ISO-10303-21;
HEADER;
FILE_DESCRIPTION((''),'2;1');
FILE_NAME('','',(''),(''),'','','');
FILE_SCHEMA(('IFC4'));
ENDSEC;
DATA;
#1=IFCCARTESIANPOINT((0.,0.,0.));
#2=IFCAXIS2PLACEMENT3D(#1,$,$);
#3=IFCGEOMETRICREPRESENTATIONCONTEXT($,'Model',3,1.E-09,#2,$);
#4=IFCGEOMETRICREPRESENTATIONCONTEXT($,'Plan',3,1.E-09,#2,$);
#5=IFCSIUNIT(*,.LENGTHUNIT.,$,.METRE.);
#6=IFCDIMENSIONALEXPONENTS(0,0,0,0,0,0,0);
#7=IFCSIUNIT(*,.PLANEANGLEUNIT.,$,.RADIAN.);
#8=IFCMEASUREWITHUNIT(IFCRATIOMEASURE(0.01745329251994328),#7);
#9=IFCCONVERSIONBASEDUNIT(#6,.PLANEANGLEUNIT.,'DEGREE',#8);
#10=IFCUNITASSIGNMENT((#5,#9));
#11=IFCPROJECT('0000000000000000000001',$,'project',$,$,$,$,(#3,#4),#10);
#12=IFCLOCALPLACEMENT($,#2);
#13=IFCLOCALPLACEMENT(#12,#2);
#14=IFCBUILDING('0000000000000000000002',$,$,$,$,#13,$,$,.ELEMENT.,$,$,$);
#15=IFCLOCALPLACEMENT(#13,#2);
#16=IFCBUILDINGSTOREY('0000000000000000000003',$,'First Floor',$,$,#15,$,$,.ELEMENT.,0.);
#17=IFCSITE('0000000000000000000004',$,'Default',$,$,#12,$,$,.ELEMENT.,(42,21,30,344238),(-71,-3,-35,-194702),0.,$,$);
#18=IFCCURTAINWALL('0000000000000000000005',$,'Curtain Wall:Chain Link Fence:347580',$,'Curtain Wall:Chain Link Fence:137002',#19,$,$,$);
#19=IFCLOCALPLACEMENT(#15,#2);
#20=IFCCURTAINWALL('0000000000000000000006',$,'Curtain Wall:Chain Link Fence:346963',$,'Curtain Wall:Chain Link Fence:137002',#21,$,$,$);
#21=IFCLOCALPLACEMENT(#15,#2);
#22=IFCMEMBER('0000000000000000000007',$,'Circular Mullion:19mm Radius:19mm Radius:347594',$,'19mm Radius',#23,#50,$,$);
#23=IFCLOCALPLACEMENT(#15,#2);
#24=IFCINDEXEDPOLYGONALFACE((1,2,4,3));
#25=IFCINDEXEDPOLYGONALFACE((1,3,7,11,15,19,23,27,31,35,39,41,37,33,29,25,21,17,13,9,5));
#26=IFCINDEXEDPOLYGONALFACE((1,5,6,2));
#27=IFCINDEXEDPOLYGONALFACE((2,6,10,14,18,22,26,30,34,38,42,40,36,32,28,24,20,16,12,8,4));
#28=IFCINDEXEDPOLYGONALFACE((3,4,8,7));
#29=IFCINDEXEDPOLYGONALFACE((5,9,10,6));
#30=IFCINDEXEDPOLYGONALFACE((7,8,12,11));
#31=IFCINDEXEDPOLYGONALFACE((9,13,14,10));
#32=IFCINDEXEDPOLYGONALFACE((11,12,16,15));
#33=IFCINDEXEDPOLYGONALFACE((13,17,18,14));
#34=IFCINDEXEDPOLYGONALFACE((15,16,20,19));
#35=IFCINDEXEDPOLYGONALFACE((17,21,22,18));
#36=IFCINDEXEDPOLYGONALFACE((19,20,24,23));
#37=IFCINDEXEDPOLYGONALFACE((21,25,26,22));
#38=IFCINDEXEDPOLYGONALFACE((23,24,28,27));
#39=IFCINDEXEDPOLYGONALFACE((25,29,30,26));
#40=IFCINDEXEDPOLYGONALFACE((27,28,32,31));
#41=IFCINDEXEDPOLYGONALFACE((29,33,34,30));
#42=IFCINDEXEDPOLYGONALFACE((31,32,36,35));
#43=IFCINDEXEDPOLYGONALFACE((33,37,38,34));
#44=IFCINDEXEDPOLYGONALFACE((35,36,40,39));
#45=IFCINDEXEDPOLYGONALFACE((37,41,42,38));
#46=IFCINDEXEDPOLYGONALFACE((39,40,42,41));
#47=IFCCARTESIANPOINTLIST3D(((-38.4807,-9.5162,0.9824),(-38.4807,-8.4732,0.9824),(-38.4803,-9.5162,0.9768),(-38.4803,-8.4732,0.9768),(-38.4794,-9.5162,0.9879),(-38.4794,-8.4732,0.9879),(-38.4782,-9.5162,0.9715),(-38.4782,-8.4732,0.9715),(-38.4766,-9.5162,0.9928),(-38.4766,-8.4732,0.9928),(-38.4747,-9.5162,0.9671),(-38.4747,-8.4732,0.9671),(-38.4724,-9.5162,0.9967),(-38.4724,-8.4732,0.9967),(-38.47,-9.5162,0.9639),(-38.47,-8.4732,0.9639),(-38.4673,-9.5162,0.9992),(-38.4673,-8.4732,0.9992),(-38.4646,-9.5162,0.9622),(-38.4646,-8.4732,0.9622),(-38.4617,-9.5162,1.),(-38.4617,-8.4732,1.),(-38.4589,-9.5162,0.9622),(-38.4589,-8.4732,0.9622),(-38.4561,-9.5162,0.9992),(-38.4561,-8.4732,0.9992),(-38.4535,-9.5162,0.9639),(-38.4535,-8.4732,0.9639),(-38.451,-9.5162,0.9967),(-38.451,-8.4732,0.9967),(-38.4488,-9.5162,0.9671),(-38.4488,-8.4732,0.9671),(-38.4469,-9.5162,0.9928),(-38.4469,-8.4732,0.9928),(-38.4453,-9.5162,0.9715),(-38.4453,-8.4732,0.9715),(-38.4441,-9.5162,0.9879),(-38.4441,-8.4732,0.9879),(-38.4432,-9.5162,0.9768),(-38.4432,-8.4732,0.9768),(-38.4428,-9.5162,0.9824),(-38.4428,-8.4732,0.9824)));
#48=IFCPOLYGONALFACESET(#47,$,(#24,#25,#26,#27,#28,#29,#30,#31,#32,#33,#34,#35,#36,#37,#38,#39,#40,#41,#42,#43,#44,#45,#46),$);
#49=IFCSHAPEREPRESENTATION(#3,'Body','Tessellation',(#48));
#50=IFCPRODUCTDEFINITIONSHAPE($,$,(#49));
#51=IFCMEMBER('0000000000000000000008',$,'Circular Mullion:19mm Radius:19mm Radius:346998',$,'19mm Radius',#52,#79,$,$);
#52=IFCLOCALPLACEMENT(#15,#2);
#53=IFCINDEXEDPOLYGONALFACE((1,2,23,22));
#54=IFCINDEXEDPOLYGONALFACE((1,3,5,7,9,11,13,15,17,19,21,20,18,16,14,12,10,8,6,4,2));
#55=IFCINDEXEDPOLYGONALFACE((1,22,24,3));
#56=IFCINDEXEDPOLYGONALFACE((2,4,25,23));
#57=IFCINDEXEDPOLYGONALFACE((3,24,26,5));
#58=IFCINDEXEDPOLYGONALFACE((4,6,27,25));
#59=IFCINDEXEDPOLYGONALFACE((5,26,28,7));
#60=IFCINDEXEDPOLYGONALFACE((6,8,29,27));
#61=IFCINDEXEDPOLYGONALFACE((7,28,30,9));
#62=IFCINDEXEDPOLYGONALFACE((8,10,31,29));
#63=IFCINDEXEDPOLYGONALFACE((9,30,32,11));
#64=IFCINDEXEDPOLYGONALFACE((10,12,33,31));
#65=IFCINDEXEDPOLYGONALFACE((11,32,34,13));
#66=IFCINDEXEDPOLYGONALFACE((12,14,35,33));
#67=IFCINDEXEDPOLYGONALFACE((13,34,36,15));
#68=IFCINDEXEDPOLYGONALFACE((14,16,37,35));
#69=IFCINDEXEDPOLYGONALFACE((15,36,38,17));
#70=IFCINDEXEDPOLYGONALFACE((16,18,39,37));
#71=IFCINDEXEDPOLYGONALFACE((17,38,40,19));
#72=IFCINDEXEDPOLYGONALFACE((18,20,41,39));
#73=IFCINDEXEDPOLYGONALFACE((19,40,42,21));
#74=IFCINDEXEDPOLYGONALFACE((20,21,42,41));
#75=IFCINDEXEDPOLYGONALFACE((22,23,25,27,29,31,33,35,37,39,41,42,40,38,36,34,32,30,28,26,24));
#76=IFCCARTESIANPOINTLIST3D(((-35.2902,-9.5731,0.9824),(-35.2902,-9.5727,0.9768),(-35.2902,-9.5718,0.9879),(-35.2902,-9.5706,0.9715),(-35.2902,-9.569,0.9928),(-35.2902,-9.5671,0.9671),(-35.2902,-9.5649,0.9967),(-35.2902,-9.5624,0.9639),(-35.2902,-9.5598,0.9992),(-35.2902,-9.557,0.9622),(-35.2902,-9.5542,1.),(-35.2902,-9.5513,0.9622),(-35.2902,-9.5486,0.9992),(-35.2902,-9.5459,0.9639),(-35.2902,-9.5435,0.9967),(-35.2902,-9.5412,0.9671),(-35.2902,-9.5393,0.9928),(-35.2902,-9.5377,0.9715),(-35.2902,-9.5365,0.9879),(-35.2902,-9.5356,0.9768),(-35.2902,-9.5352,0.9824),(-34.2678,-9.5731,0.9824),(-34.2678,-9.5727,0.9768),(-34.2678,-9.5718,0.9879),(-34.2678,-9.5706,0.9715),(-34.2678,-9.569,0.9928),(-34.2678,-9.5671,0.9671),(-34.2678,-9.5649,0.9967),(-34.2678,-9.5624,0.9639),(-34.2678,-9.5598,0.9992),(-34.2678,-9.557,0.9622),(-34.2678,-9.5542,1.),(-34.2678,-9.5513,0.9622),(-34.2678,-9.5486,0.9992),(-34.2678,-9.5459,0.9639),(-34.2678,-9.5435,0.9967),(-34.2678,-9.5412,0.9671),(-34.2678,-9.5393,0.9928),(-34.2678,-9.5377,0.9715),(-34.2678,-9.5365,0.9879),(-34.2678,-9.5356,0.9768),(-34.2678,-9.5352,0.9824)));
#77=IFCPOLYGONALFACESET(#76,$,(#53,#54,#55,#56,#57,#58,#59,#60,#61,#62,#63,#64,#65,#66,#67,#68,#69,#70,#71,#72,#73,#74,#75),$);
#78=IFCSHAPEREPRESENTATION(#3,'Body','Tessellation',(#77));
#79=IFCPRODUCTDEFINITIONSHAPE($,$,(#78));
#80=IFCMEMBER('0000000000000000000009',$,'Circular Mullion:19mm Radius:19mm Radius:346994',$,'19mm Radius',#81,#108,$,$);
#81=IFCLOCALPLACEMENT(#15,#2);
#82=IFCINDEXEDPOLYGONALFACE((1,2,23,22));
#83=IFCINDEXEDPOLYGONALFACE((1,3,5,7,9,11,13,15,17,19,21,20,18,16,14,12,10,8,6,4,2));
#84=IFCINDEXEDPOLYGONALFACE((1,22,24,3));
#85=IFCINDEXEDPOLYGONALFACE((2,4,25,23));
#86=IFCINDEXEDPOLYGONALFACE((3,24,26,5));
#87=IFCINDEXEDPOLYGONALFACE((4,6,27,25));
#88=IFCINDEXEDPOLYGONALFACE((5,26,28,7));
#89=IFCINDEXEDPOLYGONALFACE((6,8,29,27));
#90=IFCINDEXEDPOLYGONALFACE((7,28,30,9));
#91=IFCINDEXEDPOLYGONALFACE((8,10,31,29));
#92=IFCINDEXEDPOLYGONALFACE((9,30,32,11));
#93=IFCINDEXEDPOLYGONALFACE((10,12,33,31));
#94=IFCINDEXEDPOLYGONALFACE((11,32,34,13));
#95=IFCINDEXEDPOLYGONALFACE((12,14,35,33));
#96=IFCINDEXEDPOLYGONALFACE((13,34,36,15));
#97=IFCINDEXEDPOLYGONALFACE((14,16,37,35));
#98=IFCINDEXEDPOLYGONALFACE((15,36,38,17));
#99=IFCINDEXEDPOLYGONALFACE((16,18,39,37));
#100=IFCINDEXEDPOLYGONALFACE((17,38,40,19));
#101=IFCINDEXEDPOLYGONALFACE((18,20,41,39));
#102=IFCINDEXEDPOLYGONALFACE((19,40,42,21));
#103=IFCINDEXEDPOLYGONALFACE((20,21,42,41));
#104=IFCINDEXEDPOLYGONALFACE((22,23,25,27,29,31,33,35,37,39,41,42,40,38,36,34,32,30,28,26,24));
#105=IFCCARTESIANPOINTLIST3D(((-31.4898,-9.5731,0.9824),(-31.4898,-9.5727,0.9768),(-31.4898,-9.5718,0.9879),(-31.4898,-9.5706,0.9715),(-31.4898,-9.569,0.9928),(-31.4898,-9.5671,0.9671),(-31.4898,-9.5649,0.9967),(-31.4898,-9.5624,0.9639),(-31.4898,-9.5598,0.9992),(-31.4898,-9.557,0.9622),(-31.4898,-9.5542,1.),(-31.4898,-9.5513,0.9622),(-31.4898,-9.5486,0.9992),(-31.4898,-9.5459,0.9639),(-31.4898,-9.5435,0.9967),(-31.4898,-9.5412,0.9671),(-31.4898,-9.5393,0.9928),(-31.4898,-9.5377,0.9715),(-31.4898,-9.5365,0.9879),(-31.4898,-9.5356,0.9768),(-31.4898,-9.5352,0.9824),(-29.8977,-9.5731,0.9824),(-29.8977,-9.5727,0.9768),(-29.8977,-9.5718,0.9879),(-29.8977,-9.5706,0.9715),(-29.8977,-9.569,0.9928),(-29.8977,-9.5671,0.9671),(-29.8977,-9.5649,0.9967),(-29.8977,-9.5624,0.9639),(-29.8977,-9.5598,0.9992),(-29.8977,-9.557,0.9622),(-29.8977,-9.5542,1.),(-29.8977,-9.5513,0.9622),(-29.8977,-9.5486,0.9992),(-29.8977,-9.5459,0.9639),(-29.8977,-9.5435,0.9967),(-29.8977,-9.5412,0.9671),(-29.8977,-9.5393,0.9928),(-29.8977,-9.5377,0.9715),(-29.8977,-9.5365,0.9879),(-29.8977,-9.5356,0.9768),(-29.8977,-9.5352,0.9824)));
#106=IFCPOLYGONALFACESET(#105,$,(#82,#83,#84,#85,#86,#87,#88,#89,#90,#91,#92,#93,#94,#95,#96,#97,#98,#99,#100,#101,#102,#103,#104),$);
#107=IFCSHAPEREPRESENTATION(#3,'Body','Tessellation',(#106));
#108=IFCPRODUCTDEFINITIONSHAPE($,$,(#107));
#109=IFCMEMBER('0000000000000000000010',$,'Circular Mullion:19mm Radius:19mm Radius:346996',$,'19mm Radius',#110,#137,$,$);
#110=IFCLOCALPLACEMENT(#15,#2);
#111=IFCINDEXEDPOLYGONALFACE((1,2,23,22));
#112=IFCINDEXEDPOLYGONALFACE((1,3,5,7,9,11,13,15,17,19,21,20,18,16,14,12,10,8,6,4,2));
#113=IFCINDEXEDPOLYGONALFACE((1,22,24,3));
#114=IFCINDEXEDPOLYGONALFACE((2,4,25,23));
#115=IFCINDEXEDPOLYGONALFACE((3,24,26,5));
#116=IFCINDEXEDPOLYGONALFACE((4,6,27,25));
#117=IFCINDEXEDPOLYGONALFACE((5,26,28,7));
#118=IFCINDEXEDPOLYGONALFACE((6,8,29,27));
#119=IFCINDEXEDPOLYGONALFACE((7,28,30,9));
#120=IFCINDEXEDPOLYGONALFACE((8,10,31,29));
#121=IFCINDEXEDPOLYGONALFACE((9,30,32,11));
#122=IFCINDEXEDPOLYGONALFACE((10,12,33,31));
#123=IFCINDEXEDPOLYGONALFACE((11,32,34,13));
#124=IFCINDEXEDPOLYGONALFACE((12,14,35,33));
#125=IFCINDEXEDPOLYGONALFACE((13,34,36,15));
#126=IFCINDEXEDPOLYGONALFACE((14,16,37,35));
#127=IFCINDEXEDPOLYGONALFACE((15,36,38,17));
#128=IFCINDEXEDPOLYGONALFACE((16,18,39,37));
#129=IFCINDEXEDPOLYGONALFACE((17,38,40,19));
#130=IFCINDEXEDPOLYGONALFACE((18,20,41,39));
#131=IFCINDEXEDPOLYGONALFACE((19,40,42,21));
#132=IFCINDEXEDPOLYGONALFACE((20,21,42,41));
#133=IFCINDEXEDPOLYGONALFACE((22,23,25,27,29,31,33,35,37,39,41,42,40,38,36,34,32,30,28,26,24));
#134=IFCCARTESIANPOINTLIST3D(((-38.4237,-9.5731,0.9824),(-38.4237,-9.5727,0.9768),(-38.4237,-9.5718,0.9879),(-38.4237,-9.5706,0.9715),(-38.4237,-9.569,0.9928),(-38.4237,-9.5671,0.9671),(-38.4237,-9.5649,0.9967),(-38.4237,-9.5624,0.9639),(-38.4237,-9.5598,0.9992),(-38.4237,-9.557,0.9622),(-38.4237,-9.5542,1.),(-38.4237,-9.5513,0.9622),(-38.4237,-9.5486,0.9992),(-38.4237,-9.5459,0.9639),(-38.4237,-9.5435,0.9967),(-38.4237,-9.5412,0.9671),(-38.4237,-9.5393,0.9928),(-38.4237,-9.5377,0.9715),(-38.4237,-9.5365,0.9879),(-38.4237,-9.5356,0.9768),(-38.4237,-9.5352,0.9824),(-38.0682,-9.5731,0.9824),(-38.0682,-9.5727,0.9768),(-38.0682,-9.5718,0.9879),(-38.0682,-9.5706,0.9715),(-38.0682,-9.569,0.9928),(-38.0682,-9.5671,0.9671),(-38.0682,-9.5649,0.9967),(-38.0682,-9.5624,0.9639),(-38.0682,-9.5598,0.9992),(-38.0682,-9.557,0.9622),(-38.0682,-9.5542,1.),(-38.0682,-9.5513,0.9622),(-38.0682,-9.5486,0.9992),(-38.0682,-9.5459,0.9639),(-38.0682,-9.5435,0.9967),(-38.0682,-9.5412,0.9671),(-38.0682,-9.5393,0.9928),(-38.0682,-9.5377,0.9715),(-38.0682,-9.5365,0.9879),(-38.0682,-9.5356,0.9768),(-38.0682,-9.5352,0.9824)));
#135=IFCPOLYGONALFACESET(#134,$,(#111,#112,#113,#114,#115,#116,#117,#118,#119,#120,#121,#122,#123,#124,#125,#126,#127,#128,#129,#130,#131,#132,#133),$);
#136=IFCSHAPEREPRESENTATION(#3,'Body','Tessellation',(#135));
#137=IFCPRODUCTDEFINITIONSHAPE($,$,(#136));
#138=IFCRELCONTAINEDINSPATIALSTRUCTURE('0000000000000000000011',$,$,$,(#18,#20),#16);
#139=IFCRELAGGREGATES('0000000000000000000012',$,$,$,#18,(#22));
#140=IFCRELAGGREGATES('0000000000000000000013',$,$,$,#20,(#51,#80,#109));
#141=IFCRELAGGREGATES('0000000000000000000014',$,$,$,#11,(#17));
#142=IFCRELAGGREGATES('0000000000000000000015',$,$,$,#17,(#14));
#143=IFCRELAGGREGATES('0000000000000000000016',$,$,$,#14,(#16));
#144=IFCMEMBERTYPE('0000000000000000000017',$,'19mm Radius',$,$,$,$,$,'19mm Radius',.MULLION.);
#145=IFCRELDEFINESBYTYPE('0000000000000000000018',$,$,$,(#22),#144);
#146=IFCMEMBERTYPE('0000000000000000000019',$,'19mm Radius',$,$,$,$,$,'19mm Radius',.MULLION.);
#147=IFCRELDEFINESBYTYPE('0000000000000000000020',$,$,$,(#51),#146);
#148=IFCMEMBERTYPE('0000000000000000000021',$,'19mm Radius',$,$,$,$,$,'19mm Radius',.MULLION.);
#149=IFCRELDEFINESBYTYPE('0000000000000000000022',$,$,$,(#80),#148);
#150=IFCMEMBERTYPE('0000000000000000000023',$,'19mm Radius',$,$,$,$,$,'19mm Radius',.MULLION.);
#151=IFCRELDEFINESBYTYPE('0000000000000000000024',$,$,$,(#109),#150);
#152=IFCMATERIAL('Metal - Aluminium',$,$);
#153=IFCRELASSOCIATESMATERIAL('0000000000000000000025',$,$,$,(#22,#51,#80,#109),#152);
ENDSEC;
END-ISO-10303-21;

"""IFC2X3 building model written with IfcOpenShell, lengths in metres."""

from ifc_helpers import new_model, entity, si_unit, converted_unit, frame, origin, origin_2d_with_axis, place, context, project, spatial, circle, extrude, source, transform, mapped, material, type_object, type_shapes, element, aggregate, save


model = new_model("IFC2X3")

# Units and contexts
model_context = context("Model", 3, precision=1e-09, world=origin())
plan_context = context("Plan", 3, precision=1e-09, world=origin())
ifc_project = project(units=[si_unit("LENGTHUNIT", "METRE"), converted_unit("PLANEANGLEUNIT", "DEGREE", entity("IfcRatioMeasure", 0.01745329251994328), si_unit("PLANEANGLEUNIT", "RADIAN"), dimensions=[0, 0, 0, 0, 0, 0, 0])], contexts=[model_context, plan_context])

# Site, building, storey
site_placement = place(None, origin())
site = spatial("IfcSite", under=ifc_project, at=site_placement, Name="Default", CompositionType="ELEMENT", RefLatitude=(42, 21, 30, 344238), RefLongitude=(-71, -3, -35, -194702), RefElevation=0.0)
building_placement = place(site_placement, origin())
building = spatial("IfcBuilding", under=site, at=building_placement, CompositionType="ELEMENT")
storey_placement = place(building_placement, origin())
storey = spatial("IfcBuildingStorey", under=building, at=storey_placement, Name="First Floor", CompositionType="ELEMENT", Elevation=0.0)

# Curtain walls
curtain_wall_1_placement = place(storey_placement, origin())
curtain_wall_1 = element("IfcCurtainWall", 1, at=curtain_wall_1_placement, inside=storey, Name="Curtain Wall:Chain Link Fence:347580", ObjectType="Curtain Wall:Chain Link Fence:137002")
ifc_material_1 = material(Name="Metal - Aluminium")
curtain_wall_2_placement = place(storey_placement, origin())
curtain_wall_2 = element("IfcCurtainWall", 2, at=curtain_wall_2_placement, inside=storey, Name="Curtain Wall:Chain Link Fence:346963", ObjectType="Curtain Wall:Chain Link Fence:137002")

# Members
member_type_1 = type_object("IfcMemberType", Name="19mm Radius", ElementType="19mm Radius", PredefinedType="MULLION")
shared_shape_1 = source(origin(), model_context, "Body", "SweptSolid", [
    extrude(circle(Radius=0.019, at=origin_2d_with_axis()), frame((-0.019, 0.0, -1.043)), (0.0, 0.0, 1.0), 1.043),
])
type_shapes(member_type_1, [shared_shape_1])
member_1_placement = place(storey_placement, frame((-38.4617, -8.4732, 1.0), z_axis=(0.0, 1.0, 0.0), x_axis=(0.0, 0.0, 1.0)))
member_1 = element("IfcMember", 3, at=member_1_placement, type_object=member_type_1, material=ifc_material_1, Name="Circular Mullion:19mm Radius:19mm Radius:347594", ObjectType="19mm Radius", context=model_context, shape_type="MappedRepresentation", body=[
    mapped(shared_shape_1, transform((0.0, 0.0, 0.0), scale=1.0)),
])
member_type_2 = type_object("IfcMemberType", Name="19mm Radius", ElementType="19mm Radius", PredefinedType="MULLION")
shared_shape_2 = source(origin(), model_context, "Body", "SweptSolid", [
    extrude(circle(Radius=0.019, at=origin_2d_with_axis()), frame((-0.019, 0.0, -1.0224)), (0.0, 0.0, 1.0), 1.0224),
])
type_shapes(member_type_2, [shared_shape_2])
member_2_placement = place(storey_placement, frame((-34.2678, -9.5542, 1.0), z_axis=(1.0, 0.0, 0.0), x_axis=(0.0, 0.0, 1.0)))
member_2 = element("IfcMember", 4, at=member_2_placement, type_object=member_type_2, material=ifc_material_1, Name="Circular Mullion:19mm Radius:19mm Radius:346998", ObjectType="19mm Radius", context=model_context, shape_type="MappedRepresentation", body=[
    mapped(shared_shape_2, transform((0.0, 0.0, 0.0), scale=1.0)),
])
member_type_3 = type_object("IfcMemberType", Name="19mm Radius", ElementType="19mm Radius", PredefinedType="MULLION")
shared_shape_3 = source(origin(), model_context, "Body", "SweptSolid", [
    extrude(circle(Radius=0.019, at=origin_2d_with_axis()), frame((-0.019, 0.0, -1.5921)), (0.0, 0.0, 1.0), 1.5921),
])
type_shapes(member_type_3, [shared_shape_3])
member_3_placement = place(storey_placement, frame((-29.8977, -9.5542, 1.0), z_axis=(1.0, 0.0, 0.0), x_axis=(0.0, 0.0, 1.0)))
member_3 = element("IfcMember", 5, at=member_3_placement, type_object=member_type_3, material=ifc_material_1, Name="Circular Mullion:19mm Radius:19mm Radius:346994", ObjectType="19mm Radius", context=model_context, shape_type="MappedRepresentation", body=[
    mapped(shared_shape_3, transform((0.0, 0.0, 0.0), scale=1.0)),
])
member_type_4 = type_object("IfcMemberType", Name="19mm Radius", ElementType="19mm Radius", PredefinedType="MULLION")
shared_shape_4 = source(origin(), model_context, "Body", "SweptSolid", [
    extrude(circle(Radius=0.019, at=origin_2d_with_axis()), frame((-0.019, 0.0, -0.3556)), (0.0, 0.0, 1.0), 0.3556),
])
type_shapes(member_type_4, [shared_shape_4])
member_4_placement = place(storey_placement, frame((-38.0682, -9.5542, 1.0), z_axis=(1.0, 0.0, 0.0), x_axis=(0.0, 0.0, 1.0)))
member_4 = element("IfcMember", 6, at=member_4_placement, type_object=member_type_4, material=ifc_material_1, Name="Circular Mullion:19mm Radius:19mm Radius:346996", ObjectType="19mm Radius", context=model_context, shape_type="MappedRepresentation", body=[
    mapped(shared_shape_4, transform((0.0, 0.0, 0.0), scale=1.0)),
])

aggregate(curtain_wall_1, [member_1])
aggregate(curtain_wall_2, [member_2, member_3, member_4])

save(model, "model.ifc")
